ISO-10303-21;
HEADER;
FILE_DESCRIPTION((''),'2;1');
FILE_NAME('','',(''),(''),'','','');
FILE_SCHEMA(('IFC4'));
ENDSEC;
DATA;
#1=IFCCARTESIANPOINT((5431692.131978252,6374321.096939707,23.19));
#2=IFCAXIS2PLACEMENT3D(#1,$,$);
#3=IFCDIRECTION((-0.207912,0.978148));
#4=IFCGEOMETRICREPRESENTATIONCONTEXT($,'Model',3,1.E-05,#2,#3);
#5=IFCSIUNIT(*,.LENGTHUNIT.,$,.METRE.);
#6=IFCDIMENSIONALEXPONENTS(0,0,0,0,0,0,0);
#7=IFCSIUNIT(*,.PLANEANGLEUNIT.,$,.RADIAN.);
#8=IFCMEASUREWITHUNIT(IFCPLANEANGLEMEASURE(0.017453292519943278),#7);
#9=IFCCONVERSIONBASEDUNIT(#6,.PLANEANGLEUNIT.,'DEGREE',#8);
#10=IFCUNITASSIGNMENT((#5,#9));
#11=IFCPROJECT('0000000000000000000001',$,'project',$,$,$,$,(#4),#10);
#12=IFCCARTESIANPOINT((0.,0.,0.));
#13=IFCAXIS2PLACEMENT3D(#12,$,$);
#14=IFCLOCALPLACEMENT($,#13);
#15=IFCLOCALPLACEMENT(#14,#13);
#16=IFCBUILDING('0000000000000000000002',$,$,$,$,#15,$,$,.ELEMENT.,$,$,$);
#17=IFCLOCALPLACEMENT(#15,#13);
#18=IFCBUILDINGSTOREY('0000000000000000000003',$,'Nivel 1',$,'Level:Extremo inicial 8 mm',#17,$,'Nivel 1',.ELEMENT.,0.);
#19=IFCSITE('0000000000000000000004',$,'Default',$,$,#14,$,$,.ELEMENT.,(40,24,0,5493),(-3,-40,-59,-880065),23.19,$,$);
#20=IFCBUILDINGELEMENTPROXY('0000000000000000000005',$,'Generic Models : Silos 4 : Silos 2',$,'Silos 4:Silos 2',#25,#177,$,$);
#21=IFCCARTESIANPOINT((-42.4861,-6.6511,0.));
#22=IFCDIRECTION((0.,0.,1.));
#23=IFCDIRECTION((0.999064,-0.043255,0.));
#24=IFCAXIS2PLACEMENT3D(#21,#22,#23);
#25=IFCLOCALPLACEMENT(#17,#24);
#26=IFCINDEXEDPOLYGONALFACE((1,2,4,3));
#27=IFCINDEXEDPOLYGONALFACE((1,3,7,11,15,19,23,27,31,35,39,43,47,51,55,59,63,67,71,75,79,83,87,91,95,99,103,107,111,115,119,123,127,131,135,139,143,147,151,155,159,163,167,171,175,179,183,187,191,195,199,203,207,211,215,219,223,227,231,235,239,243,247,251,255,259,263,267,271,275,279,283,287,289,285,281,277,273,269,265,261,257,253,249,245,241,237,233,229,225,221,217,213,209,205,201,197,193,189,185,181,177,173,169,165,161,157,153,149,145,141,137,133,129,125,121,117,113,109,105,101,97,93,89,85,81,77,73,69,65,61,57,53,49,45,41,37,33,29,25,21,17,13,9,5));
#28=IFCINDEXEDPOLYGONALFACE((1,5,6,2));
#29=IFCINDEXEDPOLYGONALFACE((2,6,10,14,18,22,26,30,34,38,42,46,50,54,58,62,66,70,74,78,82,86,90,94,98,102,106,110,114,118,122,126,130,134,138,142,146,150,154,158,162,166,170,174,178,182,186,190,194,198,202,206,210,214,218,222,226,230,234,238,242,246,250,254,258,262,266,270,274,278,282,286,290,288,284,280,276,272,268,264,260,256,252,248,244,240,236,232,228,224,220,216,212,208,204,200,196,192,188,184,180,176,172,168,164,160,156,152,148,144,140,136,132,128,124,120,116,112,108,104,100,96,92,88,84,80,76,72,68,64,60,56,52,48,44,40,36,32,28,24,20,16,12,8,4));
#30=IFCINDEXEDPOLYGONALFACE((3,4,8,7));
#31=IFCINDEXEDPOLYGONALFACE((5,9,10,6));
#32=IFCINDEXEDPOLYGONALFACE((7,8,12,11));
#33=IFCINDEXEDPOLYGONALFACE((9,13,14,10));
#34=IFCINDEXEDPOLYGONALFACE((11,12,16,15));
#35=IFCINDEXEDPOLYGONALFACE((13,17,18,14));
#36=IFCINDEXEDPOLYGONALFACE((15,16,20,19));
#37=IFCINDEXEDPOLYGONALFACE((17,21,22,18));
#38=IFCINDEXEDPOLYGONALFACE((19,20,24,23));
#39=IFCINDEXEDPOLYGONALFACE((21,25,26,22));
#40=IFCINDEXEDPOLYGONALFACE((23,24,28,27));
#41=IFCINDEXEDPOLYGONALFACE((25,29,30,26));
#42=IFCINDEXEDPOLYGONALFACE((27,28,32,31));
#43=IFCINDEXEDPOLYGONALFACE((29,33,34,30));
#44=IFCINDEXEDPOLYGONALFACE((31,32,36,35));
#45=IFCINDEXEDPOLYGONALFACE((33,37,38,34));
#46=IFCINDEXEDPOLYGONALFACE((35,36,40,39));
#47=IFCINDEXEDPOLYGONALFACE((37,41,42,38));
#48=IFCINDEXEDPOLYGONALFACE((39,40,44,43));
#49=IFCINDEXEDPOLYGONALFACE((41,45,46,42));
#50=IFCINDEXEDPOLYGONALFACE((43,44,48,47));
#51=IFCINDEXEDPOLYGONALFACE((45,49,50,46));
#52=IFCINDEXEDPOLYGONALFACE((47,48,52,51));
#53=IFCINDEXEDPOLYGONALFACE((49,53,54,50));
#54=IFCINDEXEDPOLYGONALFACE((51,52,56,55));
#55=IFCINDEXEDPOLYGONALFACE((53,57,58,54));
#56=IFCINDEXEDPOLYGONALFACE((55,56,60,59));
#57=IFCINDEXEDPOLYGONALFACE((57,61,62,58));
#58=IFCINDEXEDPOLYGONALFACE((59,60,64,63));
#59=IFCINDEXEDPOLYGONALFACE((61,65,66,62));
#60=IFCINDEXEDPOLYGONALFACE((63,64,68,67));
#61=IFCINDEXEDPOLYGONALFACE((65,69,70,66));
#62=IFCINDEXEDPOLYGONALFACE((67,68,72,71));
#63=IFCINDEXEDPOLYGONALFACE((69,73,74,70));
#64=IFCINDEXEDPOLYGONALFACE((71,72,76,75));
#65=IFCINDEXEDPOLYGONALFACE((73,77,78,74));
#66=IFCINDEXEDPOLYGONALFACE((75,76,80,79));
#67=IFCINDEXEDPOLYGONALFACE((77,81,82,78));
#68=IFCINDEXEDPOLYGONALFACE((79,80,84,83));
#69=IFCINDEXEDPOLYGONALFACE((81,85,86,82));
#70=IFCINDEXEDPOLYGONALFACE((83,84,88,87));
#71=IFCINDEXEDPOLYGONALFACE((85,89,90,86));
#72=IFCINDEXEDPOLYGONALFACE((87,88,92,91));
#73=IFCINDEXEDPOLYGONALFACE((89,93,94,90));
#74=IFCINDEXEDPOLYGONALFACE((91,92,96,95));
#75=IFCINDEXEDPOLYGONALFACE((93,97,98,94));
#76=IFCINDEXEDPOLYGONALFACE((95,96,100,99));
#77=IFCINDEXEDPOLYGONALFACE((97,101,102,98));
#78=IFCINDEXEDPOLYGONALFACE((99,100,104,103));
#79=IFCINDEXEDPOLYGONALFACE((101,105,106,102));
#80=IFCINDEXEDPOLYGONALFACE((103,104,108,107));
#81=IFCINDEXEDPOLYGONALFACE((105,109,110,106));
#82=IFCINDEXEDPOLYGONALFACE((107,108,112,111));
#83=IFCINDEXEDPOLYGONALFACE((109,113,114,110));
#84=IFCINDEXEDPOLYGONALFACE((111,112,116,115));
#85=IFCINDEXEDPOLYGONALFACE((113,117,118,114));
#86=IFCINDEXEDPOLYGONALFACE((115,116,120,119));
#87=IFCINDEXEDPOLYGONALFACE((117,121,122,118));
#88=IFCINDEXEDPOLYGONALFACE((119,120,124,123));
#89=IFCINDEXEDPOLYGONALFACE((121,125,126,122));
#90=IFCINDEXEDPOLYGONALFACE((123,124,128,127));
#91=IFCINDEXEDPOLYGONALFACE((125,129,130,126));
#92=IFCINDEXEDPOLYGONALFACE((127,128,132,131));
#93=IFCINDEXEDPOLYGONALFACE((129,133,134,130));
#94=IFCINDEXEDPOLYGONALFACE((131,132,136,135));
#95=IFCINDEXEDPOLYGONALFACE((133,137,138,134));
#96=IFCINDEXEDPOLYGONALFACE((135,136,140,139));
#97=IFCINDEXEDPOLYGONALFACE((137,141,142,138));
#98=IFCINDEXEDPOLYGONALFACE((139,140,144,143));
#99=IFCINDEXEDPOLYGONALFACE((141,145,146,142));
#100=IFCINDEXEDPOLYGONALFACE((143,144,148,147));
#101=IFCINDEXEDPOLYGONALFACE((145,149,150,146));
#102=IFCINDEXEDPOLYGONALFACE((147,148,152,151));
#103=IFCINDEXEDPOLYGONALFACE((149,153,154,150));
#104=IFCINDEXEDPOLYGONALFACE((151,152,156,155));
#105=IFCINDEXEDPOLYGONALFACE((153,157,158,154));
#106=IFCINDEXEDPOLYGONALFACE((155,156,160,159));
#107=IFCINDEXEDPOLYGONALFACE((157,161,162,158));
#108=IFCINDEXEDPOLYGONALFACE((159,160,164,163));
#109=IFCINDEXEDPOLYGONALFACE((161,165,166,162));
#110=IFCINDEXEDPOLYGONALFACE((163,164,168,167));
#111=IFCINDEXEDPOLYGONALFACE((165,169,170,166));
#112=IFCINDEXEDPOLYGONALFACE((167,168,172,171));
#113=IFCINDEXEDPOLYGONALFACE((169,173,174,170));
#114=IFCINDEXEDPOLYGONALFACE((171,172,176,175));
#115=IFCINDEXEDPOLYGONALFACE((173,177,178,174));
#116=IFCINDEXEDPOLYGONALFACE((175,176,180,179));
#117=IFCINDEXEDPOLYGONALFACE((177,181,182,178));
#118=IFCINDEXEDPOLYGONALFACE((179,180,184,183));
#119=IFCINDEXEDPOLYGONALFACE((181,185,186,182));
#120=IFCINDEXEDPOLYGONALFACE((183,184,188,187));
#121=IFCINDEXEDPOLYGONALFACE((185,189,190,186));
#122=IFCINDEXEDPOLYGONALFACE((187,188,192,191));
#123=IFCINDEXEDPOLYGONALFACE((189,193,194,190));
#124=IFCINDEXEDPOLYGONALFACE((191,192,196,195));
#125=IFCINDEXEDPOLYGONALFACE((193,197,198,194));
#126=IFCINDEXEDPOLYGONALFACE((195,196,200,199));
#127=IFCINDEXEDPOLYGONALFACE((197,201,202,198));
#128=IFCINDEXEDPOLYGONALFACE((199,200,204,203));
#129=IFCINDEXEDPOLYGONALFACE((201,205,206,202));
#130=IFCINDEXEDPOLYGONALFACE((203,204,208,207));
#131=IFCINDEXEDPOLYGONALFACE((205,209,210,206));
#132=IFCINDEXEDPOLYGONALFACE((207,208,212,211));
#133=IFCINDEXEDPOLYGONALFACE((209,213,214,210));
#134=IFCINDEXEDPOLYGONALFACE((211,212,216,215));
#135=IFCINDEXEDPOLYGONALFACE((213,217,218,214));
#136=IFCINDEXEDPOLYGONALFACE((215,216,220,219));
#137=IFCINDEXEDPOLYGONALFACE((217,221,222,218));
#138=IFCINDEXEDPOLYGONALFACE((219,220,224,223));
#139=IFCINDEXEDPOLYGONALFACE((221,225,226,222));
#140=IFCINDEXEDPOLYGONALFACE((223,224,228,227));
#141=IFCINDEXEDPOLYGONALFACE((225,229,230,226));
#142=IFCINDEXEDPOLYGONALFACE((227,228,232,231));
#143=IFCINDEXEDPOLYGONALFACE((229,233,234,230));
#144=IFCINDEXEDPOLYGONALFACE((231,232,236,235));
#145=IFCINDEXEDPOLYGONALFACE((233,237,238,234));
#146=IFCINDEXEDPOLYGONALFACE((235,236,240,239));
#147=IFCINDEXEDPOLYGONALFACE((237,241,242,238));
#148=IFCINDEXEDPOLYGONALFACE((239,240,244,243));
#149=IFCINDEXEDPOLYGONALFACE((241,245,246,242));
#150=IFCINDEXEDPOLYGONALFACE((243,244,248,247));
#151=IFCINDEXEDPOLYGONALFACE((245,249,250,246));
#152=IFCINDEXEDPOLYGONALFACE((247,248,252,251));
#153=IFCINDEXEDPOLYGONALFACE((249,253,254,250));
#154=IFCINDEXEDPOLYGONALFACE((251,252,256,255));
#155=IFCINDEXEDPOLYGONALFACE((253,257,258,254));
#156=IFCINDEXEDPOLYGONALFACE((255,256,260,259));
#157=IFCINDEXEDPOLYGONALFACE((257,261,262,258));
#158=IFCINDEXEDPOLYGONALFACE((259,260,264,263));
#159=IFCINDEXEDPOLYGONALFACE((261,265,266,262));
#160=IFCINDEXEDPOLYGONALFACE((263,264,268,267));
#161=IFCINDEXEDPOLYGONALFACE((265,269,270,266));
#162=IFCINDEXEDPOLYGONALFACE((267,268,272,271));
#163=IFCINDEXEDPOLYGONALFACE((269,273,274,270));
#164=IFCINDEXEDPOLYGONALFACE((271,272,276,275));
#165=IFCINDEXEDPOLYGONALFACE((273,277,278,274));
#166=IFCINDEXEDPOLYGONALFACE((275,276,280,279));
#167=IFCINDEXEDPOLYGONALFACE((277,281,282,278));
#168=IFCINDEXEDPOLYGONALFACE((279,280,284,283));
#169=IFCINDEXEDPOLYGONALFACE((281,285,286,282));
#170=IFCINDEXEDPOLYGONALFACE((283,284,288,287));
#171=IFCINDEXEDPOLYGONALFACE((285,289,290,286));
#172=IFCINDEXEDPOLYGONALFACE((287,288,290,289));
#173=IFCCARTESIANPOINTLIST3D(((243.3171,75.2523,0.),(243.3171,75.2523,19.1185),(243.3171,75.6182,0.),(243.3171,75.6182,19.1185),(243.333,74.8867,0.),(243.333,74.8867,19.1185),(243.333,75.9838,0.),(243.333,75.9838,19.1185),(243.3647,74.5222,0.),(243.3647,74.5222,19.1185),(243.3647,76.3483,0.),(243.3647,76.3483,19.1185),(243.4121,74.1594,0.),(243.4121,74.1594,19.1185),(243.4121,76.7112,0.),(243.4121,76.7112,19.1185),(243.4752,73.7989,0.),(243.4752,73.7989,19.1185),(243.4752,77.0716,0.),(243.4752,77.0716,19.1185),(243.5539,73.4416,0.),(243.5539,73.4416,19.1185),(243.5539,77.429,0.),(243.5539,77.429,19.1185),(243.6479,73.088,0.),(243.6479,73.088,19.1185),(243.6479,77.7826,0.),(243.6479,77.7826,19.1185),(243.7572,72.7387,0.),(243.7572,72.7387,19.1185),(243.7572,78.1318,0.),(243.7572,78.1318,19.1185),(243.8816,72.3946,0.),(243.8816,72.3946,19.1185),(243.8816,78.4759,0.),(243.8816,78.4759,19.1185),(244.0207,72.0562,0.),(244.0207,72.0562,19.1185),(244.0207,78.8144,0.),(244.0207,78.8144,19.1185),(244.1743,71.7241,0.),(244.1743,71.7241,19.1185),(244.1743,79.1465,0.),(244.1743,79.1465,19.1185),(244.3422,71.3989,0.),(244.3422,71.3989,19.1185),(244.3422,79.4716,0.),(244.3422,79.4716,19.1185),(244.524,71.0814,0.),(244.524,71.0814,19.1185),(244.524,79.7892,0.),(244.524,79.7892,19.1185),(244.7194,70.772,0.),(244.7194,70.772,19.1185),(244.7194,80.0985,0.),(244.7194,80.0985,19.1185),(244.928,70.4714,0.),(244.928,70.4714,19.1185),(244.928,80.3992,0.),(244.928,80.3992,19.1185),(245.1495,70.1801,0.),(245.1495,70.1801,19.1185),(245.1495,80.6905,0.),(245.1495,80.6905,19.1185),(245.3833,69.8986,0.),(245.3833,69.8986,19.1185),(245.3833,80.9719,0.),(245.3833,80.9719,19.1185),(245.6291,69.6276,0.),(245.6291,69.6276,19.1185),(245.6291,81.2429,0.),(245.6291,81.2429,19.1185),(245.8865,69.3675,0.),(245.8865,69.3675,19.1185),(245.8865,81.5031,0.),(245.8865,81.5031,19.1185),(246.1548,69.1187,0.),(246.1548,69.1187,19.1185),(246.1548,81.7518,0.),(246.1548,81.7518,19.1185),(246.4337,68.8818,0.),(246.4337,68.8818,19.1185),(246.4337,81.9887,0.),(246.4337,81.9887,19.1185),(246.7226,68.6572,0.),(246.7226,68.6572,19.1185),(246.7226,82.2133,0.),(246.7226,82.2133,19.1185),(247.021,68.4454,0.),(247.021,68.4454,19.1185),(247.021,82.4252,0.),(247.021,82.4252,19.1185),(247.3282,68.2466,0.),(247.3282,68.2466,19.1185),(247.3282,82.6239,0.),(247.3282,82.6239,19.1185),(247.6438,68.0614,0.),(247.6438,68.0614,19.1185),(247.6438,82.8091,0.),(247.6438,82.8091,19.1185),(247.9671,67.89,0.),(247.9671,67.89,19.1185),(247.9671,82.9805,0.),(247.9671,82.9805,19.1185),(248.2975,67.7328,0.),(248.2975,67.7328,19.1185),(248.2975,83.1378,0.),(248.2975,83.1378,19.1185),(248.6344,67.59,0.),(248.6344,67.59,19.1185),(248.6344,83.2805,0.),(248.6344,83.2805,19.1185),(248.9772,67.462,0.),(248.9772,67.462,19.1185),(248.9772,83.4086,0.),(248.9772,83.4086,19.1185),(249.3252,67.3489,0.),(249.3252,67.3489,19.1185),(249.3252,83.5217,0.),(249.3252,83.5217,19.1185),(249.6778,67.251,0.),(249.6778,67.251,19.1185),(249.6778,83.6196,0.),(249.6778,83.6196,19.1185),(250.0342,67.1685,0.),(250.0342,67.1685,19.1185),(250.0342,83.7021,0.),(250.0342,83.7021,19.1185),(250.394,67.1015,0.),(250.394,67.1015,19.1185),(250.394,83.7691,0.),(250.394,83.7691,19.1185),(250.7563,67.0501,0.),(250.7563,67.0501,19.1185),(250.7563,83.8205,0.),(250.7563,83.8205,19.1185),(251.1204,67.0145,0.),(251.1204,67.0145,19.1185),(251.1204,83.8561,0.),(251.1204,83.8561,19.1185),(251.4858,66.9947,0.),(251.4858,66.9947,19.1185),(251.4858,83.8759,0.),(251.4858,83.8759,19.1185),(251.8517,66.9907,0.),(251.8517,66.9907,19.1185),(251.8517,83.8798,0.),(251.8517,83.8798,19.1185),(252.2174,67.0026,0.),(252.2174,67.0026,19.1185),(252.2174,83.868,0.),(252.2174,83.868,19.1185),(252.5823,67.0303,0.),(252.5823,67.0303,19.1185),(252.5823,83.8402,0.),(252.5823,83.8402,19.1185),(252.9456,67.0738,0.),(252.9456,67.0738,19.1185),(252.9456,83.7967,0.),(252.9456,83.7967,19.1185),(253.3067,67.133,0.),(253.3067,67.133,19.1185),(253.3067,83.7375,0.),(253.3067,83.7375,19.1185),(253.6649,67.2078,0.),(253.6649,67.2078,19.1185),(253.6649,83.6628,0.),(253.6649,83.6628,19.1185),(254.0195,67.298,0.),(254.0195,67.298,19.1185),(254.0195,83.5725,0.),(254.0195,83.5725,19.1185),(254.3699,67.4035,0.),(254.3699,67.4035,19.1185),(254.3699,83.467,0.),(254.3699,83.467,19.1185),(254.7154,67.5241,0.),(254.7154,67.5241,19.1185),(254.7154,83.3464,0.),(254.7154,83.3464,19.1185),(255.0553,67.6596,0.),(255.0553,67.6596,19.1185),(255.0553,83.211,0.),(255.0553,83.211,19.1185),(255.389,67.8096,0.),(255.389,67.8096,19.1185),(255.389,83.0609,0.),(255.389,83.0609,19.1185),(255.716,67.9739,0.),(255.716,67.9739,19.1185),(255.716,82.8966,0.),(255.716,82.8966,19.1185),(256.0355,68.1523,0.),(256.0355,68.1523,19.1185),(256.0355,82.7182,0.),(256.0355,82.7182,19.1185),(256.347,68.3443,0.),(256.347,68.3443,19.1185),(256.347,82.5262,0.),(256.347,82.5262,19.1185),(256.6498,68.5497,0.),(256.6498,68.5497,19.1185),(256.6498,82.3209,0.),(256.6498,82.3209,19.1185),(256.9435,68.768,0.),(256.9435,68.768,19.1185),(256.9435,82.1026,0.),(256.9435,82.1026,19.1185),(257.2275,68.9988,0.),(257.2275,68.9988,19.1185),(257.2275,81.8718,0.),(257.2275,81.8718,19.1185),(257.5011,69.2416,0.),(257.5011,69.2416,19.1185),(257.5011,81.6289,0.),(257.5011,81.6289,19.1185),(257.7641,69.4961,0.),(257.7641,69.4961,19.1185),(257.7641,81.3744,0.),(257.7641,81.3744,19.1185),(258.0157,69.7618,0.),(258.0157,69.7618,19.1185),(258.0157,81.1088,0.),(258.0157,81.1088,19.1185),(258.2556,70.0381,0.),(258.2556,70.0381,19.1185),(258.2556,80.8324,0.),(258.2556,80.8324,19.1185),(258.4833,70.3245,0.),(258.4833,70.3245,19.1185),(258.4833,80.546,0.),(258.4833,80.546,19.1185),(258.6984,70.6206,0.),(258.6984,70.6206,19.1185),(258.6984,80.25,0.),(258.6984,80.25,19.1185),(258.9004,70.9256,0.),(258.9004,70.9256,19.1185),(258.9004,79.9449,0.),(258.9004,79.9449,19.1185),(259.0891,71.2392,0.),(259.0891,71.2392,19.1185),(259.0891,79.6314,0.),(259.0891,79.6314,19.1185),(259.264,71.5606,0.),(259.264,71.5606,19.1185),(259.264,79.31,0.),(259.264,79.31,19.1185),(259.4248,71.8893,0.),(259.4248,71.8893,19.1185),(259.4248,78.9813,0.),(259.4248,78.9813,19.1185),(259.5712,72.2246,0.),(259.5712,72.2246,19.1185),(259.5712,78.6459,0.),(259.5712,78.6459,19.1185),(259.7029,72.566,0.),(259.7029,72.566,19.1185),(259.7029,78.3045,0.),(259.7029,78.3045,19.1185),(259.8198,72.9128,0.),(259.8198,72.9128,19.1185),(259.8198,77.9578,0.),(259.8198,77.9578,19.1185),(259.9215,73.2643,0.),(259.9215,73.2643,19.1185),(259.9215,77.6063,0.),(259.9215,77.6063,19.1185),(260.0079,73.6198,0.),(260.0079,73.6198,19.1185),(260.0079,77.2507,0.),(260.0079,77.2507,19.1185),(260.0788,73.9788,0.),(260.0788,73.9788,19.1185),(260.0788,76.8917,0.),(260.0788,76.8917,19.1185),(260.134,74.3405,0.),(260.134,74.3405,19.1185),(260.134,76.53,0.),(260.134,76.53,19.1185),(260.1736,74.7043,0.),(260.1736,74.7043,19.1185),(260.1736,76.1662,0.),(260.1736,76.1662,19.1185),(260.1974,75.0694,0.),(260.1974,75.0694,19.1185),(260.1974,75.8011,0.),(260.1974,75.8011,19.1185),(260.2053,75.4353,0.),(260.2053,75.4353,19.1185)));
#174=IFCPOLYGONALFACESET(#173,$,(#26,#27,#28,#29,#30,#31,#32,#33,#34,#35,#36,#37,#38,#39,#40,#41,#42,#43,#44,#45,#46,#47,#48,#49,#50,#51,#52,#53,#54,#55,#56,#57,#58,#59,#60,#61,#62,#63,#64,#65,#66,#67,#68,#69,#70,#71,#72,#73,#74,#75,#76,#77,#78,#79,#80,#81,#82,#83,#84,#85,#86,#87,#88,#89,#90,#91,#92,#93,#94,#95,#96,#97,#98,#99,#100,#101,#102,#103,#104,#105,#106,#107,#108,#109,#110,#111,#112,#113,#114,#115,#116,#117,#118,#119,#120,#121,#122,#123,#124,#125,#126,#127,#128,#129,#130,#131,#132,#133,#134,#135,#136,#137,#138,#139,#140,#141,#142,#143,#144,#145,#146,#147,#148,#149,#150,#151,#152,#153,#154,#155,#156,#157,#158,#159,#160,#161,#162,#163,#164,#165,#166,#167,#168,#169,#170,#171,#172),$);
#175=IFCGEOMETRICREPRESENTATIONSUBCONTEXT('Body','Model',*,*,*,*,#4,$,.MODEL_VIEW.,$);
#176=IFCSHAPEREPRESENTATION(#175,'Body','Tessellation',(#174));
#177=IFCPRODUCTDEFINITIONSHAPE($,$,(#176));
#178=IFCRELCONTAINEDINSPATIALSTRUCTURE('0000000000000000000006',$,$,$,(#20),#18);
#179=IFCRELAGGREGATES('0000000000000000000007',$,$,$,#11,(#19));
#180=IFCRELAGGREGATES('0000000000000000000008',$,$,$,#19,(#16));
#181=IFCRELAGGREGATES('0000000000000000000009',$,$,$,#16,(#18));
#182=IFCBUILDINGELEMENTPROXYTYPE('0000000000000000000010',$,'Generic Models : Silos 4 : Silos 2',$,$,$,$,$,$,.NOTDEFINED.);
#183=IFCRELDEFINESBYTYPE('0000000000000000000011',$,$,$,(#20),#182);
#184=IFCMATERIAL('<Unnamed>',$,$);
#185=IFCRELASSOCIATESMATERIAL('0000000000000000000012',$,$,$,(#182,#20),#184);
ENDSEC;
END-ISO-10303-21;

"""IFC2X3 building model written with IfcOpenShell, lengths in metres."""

from ifc_helpers import new_model, entity, si_unit, converted_unit, direction, frame, frame_2d, origin, place, context, subcontext, project, spatial, circle, extrude, source, transform, mapped, material, type_object, type_shapes, element, save


model = new_model("IFC2X3")

# Units and contexts
model_context = context("Model", 3, precision=1e-05, world=frame((5431692.131978252, 6374321.096939707, 23.19)), true_north=direction((-0.207912, 0.978148)))
body_context = subcontext(model_context, "Body", "Model", "MODEL_VIEW")
ifc_project = project(units=[si_unit("LENGTHUNIT", "METRE"), converted_unit("PLANEANGLEUNIT", "DEGREE", entity("IfcPlaneAngleMeasure", 0.017453292519943278), si_unit("PLANEANGLEUNIT", "RADIAN"), dimensions=[0, 0, 0, 0, 0, 0, 0])], contexts=[model_context])

# Site, building, storey
site_placement = place(None, origin())
site = spatial("IfcSite", under=ifc_project, at=site_placement, Name="Default", CompositionType="ELEMENT", RefLatitude=(40, 24, 0, 5493), RefLongitude=(-3, -40, -59, -880065), RefElevation=23.19)
building_placement = place(site_placement, origin())
building = spatial("IfcBuilding", under=site, at=building_placement, CompositionType="ELEMENT")
storey_placement = place(building_placement, origin())
storey = spatial("IfcBuildingStorey", under=building, at=storey_placement, Name="Nivel 1", ObjectType="Level:Extremo inicial 8 mm", LongName="Nivel 1", CompositionType="ELEMENT", Elevation=0.0)

# Building element proxy
ifc_material_1 = material(Name="<Unnamed>")
building_element_proxy_type_1 = type_object("IfcBuildingElementProxyType", Name="Generic Models : Silos 4 : Silos 2", PredefinedType="NOTDEFINED", material=ifc_material_1)
shared_shape_1 = source(origin(), body_context, "Body", "SweptSolid", [
    extrude(circle(Radius=8.4451, at=frame_2d((0.0, 0.0), x_axis=(1.0, 0.0))), frame((251.7602, 75.4353, 0.0)), (0.0, 0.0, 1.0), 19.1185),
])
type_shapes(building_element_proxy_type_1, [shared_shape_1])
proxy_1_placement = place(storey_placement, frame((-42.4861, -6.6511, 0.0), z_axis=(0.0, 0.0, 1.0), x_axis=(0.999064, -0.043255, 0.0)))
element("IfcBuildingElementProxy", 1, at=proxy_1_placement, inside=storey, type_object=building_element_proxy_type_1, material=ifc_material_1, Name="Generic Models : Silos 4 : Silos 2", ObjectType="Silos 4:Silos 2", context=body_context, shape_type="MappedRepresentation", body=[
    mapped(shared_shape_1, transform((0.0, 0.0, 0.0), scale=1.0)),
])

save(model, "model.ifc")
